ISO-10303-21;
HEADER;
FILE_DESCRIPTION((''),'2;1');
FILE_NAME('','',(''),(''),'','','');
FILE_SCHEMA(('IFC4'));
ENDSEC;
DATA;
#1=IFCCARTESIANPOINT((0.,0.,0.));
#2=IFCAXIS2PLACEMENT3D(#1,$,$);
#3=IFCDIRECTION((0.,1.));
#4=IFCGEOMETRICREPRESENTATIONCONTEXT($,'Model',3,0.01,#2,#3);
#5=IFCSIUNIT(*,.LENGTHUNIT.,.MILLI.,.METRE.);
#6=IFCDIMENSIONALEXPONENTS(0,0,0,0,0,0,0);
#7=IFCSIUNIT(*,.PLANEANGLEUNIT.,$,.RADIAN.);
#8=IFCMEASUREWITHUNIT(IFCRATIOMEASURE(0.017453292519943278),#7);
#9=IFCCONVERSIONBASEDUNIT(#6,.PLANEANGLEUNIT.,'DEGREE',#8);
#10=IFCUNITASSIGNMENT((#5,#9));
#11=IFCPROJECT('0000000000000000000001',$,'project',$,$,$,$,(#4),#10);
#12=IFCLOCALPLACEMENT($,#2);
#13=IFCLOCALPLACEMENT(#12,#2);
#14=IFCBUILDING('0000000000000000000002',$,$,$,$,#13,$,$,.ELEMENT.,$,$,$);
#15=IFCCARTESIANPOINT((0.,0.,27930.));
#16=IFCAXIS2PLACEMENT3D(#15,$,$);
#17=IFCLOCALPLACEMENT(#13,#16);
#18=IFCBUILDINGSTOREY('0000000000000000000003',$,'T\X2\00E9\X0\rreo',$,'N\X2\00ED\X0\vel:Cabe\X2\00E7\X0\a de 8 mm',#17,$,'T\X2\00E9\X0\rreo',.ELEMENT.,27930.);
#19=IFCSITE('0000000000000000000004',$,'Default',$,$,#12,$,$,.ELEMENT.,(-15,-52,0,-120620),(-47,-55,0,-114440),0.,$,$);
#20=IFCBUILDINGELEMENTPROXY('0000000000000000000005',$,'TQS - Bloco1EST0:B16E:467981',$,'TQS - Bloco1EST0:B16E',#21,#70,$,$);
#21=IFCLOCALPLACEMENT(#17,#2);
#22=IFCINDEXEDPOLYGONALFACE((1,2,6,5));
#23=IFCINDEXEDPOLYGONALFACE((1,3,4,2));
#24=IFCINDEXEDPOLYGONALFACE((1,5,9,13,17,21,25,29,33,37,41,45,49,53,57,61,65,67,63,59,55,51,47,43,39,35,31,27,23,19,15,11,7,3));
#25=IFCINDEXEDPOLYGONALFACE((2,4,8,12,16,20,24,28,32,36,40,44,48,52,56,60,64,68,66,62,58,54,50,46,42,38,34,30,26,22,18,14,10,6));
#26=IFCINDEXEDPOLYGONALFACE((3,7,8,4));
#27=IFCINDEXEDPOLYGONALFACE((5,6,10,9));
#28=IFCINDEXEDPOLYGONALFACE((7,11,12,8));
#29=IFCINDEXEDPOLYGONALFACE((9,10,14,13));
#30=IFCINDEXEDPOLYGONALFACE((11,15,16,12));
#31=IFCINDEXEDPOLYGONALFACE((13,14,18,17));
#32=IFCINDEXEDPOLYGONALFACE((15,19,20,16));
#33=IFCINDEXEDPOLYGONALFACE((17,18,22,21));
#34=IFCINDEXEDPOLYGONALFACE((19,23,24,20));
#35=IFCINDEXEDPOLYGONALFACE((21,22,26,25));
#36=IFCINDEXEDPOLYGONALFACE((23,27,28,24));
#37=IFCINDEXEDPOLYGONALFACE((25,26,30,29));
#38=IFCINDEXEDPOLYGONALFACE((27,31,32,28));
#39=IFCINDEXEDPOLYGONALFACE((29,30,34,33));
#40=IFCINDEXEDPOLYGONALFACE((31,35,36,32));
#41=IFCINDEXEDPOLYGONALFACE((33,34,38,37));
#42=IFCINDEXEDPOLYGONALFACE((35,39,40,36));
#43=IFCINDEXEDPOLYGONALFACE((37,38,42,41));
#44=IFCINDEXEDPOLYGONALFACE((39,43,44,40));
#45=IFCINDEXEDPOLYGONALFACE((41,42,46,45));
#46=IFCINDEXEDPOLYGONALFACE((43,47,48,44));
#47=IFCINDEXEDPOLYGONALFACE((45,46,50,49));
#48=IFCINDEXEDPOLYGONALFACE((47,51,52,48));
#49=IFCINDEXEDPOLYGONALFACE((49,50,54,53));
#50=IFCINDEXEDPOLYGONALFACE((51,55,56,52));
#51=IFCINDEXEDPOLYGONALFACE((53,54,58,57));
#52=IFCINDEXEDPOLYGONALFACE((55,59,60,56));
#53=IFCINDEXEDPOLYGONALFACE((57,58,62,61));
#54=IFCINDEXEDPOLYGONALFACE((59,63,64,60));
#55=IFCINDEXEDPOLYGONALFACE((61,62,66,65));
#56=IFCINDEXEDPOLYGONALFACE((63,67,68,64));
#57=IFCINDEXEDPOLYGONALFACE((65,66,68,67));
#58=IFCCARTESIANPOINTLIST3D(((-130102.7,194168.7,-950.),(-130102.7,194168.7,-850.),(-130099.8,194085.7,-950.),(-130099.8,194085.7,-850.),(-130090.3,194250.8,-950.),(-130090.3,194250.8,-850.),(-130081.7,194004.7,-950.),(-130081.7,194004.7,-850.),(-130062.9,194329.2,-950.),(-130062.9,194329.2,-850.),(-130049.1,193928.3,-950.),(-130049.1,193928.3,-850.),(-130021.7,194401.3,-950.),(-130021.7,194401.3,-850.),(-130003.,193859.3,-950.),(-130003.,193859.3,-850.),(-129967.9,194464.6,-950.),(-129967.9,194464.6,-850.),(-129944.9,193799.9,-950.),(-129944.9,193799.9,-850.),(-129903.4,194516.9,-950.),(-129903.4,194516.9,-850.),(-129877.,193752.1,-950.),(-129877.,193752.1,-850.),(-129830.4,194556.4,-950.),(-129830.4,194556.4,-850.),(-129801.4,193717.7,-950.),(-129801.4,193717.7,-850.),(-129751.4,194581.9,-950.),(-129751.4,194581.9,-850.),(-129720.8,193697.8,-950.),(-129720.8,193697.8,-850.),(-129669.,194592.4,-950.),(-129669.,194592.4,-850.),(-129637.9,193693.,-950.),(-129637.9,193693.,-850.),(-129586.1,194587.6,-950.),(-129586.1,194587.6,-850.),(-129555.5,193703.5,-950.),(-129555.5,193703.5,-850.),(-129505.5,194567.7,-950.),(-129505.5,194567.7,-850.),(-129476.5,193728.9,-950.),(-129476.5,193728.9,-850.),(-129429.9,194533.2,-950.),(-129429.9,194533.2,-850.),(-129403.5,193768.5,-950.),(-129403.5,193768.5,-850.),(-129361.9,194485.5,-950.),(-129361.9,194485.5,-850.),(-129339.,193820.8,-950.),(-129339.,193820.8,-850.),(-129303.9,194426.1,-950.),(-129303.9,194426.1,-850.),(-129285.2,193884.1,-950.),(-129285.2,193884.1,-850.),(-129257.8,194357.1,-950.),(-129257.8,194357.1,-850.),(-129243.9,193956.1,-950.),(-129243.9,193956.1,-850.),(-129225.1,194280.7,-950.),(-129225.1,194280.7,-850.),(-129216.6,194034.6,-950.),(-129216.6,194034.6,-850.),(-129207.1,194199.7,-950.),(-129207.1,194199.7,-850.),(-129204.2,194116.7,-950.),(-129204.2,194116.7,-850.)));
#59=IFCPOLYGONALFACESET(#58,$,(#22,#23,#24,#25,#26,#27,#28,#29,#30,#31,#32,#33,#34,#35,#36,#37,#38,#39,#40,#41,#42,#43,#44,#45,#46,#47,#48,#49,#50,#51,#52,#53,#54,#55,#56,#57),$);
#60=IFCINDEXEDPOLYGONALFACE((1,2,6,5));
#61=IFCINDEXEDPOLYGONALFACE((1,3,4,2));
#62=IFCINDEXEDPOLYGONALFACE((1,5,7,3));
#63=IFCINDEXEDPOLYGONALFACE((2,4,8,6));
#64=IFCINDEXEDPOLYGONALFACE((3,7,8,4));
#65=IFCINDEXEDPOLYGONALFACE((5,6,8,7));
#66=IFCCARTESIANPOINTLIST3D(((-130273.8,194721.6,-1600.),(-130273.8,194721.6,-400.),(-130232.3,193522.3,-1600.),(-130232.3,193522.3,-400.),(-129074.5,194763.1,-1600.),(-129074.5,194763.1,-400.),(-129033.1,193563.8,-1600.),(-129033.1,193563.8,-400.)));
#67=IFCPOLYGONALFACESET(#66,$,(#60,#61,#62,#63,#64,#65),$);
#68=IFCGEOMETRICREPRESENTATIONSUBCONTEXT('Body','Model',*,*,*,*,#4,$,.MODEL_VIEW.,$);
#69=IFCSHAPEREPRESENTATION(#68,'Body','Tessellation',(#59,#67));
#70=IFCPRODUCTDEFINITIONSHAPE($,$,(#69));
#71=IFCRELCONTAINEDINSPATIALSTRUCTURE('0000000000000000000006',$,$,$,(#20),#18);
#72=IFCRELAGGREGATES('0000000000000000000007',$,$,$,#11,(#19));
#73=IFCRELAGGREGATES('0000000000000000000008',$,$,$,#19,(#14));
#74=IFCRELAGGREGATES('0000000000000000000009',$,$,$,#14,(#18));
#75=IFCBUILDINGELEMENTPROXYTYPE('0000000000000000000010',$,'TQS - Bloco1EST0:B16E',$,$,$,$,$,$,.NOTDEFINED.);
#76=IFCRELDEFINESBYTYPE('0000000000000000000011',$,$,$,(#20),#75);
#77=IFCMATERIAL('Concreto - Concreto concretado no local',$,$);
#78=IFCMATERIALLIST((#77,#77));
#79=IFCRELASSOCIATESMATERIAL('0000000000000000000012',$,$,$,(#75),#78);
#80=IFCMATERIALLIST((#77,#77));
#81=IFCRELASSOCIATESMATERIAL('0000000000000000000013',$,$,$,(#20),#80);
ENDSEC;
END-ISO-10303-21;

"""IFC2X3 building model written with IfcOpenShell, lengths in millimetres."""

from ifc_helpers import new_model, entity, si_unit, converted_unit, direction, frame, frame_2d, origin, origin_2d_with_axis, place, context, subcontext, project, spatial, rectangle, circle, extrude, source, transform, mapped, material, material_list, type_object, type_shapes, element, save


model = new_model("IFC2X3")

# Units and contexts
model_context = context("Model", 3, precision=0.01, world=origin(), true_north=direction((0.0, 1.0)))
body_context = subcontext(model_context, "Body", "Model", "MODEL_VIEW")
ifc_project = project(units=[si_unit("LENGTHUNIT", "METRE", prefix="MILLI"), converted_unit("PLANEANGLEUNIT", "DEGREE", entity("IfcRatioMeasure", 0.017453292519943278), si_unit("PLANEANGLEUNIT", "RADIAN"), dimensions=[0, 0, 0, 0, 0, 0, 0])], contexts=[model_context])

# Site, building, storey
site_placement = place(None, origin())
site = spatial("IfcSite", under=ifc_project, at=site_placement, Name="Default", CompositionType="ELEMENT", RefLatitude=(-15, -52, 0, -120620), RefLongitude=(-47, -55, 0, -114440), RefElevation=0.0)
building_placement = place(site_placement, origin())
building = spatial("IfcBuilding", under=site, at=building_placement, CompositionType="ELEMENT")
storey_placement = place(building_placement, frame((0.0, 0.0, 27930.0)))
storey = spatial("IfcBuildingStorey", under=building, at=storey_placement, Name="Térreo", ObjectType="Nível:Cabeça de 8 mm", LongName="Térreo", CompositionType="ELEMENT", Elevation=27930.0)

# Building element proxy
ifc_material_1 = material(Name="Concreto - Concreto concretado no local")
ifc_material_list_1 = material_list([ifc_material_1, ifc_material_1])
ifc_material_list_2 = material_list([ifc_material_1, ifc_material_1])
building_element_proxy_type_1 = type_object("IfcBuildingElementProxyType", Name="TQS - Bloco1EST0:B16E", PredefinedType="NOTDEFINED", material=ifc_material_list_2)
shared_shape_1 = source(origin(), body_context, "Body", "SweptSolid", [
    extrude(circle(Radius=450.0, at=frame_2d((0.0, 0.0), x_axis=(1.0, 0.0))), frame((0.0, 0.0, -550.0)), (0.0, 0.0, 1.0), 100.0),
    extrude(rectangle(XDim=1200.0, YDim=1200.0, at=origin_2d_with_axis()), frame((0.0, 0.0, -1200.0), z_axis=(0.0, 0.0, 1.0), x_axis=(-1.0, 0.0, 0.0)), (0.0, 0.0, 1.0), 1200.0),
])
type_shapes(building_element_proxy_type_1, [shared_shape_1])
proxy_1_placement = place(storey_placement, frame((-129653.4, 194142.7, -400.0), z_axis=(0.0, 0.0, 1.0), x_axis=(-0.034551, 0.999403, 0.0)))
element("IfcBuildingElementProxy", 1, at=proxy_1_placement, inside=storey, type_object=building_element_proxy_type_1, material=ifc_material_list_1, Name="TQS - Bloco1EST0:B16E:467981", ObjectType="TQS - Bloco1EST0:B16E", context=body_context, shape_type="MappedRepresentation", body=[
    mapped(shared_shape_1, transform((0.0, 0.0, 0.0), scale=1.0)),
])

save(model, "model.ifc")
